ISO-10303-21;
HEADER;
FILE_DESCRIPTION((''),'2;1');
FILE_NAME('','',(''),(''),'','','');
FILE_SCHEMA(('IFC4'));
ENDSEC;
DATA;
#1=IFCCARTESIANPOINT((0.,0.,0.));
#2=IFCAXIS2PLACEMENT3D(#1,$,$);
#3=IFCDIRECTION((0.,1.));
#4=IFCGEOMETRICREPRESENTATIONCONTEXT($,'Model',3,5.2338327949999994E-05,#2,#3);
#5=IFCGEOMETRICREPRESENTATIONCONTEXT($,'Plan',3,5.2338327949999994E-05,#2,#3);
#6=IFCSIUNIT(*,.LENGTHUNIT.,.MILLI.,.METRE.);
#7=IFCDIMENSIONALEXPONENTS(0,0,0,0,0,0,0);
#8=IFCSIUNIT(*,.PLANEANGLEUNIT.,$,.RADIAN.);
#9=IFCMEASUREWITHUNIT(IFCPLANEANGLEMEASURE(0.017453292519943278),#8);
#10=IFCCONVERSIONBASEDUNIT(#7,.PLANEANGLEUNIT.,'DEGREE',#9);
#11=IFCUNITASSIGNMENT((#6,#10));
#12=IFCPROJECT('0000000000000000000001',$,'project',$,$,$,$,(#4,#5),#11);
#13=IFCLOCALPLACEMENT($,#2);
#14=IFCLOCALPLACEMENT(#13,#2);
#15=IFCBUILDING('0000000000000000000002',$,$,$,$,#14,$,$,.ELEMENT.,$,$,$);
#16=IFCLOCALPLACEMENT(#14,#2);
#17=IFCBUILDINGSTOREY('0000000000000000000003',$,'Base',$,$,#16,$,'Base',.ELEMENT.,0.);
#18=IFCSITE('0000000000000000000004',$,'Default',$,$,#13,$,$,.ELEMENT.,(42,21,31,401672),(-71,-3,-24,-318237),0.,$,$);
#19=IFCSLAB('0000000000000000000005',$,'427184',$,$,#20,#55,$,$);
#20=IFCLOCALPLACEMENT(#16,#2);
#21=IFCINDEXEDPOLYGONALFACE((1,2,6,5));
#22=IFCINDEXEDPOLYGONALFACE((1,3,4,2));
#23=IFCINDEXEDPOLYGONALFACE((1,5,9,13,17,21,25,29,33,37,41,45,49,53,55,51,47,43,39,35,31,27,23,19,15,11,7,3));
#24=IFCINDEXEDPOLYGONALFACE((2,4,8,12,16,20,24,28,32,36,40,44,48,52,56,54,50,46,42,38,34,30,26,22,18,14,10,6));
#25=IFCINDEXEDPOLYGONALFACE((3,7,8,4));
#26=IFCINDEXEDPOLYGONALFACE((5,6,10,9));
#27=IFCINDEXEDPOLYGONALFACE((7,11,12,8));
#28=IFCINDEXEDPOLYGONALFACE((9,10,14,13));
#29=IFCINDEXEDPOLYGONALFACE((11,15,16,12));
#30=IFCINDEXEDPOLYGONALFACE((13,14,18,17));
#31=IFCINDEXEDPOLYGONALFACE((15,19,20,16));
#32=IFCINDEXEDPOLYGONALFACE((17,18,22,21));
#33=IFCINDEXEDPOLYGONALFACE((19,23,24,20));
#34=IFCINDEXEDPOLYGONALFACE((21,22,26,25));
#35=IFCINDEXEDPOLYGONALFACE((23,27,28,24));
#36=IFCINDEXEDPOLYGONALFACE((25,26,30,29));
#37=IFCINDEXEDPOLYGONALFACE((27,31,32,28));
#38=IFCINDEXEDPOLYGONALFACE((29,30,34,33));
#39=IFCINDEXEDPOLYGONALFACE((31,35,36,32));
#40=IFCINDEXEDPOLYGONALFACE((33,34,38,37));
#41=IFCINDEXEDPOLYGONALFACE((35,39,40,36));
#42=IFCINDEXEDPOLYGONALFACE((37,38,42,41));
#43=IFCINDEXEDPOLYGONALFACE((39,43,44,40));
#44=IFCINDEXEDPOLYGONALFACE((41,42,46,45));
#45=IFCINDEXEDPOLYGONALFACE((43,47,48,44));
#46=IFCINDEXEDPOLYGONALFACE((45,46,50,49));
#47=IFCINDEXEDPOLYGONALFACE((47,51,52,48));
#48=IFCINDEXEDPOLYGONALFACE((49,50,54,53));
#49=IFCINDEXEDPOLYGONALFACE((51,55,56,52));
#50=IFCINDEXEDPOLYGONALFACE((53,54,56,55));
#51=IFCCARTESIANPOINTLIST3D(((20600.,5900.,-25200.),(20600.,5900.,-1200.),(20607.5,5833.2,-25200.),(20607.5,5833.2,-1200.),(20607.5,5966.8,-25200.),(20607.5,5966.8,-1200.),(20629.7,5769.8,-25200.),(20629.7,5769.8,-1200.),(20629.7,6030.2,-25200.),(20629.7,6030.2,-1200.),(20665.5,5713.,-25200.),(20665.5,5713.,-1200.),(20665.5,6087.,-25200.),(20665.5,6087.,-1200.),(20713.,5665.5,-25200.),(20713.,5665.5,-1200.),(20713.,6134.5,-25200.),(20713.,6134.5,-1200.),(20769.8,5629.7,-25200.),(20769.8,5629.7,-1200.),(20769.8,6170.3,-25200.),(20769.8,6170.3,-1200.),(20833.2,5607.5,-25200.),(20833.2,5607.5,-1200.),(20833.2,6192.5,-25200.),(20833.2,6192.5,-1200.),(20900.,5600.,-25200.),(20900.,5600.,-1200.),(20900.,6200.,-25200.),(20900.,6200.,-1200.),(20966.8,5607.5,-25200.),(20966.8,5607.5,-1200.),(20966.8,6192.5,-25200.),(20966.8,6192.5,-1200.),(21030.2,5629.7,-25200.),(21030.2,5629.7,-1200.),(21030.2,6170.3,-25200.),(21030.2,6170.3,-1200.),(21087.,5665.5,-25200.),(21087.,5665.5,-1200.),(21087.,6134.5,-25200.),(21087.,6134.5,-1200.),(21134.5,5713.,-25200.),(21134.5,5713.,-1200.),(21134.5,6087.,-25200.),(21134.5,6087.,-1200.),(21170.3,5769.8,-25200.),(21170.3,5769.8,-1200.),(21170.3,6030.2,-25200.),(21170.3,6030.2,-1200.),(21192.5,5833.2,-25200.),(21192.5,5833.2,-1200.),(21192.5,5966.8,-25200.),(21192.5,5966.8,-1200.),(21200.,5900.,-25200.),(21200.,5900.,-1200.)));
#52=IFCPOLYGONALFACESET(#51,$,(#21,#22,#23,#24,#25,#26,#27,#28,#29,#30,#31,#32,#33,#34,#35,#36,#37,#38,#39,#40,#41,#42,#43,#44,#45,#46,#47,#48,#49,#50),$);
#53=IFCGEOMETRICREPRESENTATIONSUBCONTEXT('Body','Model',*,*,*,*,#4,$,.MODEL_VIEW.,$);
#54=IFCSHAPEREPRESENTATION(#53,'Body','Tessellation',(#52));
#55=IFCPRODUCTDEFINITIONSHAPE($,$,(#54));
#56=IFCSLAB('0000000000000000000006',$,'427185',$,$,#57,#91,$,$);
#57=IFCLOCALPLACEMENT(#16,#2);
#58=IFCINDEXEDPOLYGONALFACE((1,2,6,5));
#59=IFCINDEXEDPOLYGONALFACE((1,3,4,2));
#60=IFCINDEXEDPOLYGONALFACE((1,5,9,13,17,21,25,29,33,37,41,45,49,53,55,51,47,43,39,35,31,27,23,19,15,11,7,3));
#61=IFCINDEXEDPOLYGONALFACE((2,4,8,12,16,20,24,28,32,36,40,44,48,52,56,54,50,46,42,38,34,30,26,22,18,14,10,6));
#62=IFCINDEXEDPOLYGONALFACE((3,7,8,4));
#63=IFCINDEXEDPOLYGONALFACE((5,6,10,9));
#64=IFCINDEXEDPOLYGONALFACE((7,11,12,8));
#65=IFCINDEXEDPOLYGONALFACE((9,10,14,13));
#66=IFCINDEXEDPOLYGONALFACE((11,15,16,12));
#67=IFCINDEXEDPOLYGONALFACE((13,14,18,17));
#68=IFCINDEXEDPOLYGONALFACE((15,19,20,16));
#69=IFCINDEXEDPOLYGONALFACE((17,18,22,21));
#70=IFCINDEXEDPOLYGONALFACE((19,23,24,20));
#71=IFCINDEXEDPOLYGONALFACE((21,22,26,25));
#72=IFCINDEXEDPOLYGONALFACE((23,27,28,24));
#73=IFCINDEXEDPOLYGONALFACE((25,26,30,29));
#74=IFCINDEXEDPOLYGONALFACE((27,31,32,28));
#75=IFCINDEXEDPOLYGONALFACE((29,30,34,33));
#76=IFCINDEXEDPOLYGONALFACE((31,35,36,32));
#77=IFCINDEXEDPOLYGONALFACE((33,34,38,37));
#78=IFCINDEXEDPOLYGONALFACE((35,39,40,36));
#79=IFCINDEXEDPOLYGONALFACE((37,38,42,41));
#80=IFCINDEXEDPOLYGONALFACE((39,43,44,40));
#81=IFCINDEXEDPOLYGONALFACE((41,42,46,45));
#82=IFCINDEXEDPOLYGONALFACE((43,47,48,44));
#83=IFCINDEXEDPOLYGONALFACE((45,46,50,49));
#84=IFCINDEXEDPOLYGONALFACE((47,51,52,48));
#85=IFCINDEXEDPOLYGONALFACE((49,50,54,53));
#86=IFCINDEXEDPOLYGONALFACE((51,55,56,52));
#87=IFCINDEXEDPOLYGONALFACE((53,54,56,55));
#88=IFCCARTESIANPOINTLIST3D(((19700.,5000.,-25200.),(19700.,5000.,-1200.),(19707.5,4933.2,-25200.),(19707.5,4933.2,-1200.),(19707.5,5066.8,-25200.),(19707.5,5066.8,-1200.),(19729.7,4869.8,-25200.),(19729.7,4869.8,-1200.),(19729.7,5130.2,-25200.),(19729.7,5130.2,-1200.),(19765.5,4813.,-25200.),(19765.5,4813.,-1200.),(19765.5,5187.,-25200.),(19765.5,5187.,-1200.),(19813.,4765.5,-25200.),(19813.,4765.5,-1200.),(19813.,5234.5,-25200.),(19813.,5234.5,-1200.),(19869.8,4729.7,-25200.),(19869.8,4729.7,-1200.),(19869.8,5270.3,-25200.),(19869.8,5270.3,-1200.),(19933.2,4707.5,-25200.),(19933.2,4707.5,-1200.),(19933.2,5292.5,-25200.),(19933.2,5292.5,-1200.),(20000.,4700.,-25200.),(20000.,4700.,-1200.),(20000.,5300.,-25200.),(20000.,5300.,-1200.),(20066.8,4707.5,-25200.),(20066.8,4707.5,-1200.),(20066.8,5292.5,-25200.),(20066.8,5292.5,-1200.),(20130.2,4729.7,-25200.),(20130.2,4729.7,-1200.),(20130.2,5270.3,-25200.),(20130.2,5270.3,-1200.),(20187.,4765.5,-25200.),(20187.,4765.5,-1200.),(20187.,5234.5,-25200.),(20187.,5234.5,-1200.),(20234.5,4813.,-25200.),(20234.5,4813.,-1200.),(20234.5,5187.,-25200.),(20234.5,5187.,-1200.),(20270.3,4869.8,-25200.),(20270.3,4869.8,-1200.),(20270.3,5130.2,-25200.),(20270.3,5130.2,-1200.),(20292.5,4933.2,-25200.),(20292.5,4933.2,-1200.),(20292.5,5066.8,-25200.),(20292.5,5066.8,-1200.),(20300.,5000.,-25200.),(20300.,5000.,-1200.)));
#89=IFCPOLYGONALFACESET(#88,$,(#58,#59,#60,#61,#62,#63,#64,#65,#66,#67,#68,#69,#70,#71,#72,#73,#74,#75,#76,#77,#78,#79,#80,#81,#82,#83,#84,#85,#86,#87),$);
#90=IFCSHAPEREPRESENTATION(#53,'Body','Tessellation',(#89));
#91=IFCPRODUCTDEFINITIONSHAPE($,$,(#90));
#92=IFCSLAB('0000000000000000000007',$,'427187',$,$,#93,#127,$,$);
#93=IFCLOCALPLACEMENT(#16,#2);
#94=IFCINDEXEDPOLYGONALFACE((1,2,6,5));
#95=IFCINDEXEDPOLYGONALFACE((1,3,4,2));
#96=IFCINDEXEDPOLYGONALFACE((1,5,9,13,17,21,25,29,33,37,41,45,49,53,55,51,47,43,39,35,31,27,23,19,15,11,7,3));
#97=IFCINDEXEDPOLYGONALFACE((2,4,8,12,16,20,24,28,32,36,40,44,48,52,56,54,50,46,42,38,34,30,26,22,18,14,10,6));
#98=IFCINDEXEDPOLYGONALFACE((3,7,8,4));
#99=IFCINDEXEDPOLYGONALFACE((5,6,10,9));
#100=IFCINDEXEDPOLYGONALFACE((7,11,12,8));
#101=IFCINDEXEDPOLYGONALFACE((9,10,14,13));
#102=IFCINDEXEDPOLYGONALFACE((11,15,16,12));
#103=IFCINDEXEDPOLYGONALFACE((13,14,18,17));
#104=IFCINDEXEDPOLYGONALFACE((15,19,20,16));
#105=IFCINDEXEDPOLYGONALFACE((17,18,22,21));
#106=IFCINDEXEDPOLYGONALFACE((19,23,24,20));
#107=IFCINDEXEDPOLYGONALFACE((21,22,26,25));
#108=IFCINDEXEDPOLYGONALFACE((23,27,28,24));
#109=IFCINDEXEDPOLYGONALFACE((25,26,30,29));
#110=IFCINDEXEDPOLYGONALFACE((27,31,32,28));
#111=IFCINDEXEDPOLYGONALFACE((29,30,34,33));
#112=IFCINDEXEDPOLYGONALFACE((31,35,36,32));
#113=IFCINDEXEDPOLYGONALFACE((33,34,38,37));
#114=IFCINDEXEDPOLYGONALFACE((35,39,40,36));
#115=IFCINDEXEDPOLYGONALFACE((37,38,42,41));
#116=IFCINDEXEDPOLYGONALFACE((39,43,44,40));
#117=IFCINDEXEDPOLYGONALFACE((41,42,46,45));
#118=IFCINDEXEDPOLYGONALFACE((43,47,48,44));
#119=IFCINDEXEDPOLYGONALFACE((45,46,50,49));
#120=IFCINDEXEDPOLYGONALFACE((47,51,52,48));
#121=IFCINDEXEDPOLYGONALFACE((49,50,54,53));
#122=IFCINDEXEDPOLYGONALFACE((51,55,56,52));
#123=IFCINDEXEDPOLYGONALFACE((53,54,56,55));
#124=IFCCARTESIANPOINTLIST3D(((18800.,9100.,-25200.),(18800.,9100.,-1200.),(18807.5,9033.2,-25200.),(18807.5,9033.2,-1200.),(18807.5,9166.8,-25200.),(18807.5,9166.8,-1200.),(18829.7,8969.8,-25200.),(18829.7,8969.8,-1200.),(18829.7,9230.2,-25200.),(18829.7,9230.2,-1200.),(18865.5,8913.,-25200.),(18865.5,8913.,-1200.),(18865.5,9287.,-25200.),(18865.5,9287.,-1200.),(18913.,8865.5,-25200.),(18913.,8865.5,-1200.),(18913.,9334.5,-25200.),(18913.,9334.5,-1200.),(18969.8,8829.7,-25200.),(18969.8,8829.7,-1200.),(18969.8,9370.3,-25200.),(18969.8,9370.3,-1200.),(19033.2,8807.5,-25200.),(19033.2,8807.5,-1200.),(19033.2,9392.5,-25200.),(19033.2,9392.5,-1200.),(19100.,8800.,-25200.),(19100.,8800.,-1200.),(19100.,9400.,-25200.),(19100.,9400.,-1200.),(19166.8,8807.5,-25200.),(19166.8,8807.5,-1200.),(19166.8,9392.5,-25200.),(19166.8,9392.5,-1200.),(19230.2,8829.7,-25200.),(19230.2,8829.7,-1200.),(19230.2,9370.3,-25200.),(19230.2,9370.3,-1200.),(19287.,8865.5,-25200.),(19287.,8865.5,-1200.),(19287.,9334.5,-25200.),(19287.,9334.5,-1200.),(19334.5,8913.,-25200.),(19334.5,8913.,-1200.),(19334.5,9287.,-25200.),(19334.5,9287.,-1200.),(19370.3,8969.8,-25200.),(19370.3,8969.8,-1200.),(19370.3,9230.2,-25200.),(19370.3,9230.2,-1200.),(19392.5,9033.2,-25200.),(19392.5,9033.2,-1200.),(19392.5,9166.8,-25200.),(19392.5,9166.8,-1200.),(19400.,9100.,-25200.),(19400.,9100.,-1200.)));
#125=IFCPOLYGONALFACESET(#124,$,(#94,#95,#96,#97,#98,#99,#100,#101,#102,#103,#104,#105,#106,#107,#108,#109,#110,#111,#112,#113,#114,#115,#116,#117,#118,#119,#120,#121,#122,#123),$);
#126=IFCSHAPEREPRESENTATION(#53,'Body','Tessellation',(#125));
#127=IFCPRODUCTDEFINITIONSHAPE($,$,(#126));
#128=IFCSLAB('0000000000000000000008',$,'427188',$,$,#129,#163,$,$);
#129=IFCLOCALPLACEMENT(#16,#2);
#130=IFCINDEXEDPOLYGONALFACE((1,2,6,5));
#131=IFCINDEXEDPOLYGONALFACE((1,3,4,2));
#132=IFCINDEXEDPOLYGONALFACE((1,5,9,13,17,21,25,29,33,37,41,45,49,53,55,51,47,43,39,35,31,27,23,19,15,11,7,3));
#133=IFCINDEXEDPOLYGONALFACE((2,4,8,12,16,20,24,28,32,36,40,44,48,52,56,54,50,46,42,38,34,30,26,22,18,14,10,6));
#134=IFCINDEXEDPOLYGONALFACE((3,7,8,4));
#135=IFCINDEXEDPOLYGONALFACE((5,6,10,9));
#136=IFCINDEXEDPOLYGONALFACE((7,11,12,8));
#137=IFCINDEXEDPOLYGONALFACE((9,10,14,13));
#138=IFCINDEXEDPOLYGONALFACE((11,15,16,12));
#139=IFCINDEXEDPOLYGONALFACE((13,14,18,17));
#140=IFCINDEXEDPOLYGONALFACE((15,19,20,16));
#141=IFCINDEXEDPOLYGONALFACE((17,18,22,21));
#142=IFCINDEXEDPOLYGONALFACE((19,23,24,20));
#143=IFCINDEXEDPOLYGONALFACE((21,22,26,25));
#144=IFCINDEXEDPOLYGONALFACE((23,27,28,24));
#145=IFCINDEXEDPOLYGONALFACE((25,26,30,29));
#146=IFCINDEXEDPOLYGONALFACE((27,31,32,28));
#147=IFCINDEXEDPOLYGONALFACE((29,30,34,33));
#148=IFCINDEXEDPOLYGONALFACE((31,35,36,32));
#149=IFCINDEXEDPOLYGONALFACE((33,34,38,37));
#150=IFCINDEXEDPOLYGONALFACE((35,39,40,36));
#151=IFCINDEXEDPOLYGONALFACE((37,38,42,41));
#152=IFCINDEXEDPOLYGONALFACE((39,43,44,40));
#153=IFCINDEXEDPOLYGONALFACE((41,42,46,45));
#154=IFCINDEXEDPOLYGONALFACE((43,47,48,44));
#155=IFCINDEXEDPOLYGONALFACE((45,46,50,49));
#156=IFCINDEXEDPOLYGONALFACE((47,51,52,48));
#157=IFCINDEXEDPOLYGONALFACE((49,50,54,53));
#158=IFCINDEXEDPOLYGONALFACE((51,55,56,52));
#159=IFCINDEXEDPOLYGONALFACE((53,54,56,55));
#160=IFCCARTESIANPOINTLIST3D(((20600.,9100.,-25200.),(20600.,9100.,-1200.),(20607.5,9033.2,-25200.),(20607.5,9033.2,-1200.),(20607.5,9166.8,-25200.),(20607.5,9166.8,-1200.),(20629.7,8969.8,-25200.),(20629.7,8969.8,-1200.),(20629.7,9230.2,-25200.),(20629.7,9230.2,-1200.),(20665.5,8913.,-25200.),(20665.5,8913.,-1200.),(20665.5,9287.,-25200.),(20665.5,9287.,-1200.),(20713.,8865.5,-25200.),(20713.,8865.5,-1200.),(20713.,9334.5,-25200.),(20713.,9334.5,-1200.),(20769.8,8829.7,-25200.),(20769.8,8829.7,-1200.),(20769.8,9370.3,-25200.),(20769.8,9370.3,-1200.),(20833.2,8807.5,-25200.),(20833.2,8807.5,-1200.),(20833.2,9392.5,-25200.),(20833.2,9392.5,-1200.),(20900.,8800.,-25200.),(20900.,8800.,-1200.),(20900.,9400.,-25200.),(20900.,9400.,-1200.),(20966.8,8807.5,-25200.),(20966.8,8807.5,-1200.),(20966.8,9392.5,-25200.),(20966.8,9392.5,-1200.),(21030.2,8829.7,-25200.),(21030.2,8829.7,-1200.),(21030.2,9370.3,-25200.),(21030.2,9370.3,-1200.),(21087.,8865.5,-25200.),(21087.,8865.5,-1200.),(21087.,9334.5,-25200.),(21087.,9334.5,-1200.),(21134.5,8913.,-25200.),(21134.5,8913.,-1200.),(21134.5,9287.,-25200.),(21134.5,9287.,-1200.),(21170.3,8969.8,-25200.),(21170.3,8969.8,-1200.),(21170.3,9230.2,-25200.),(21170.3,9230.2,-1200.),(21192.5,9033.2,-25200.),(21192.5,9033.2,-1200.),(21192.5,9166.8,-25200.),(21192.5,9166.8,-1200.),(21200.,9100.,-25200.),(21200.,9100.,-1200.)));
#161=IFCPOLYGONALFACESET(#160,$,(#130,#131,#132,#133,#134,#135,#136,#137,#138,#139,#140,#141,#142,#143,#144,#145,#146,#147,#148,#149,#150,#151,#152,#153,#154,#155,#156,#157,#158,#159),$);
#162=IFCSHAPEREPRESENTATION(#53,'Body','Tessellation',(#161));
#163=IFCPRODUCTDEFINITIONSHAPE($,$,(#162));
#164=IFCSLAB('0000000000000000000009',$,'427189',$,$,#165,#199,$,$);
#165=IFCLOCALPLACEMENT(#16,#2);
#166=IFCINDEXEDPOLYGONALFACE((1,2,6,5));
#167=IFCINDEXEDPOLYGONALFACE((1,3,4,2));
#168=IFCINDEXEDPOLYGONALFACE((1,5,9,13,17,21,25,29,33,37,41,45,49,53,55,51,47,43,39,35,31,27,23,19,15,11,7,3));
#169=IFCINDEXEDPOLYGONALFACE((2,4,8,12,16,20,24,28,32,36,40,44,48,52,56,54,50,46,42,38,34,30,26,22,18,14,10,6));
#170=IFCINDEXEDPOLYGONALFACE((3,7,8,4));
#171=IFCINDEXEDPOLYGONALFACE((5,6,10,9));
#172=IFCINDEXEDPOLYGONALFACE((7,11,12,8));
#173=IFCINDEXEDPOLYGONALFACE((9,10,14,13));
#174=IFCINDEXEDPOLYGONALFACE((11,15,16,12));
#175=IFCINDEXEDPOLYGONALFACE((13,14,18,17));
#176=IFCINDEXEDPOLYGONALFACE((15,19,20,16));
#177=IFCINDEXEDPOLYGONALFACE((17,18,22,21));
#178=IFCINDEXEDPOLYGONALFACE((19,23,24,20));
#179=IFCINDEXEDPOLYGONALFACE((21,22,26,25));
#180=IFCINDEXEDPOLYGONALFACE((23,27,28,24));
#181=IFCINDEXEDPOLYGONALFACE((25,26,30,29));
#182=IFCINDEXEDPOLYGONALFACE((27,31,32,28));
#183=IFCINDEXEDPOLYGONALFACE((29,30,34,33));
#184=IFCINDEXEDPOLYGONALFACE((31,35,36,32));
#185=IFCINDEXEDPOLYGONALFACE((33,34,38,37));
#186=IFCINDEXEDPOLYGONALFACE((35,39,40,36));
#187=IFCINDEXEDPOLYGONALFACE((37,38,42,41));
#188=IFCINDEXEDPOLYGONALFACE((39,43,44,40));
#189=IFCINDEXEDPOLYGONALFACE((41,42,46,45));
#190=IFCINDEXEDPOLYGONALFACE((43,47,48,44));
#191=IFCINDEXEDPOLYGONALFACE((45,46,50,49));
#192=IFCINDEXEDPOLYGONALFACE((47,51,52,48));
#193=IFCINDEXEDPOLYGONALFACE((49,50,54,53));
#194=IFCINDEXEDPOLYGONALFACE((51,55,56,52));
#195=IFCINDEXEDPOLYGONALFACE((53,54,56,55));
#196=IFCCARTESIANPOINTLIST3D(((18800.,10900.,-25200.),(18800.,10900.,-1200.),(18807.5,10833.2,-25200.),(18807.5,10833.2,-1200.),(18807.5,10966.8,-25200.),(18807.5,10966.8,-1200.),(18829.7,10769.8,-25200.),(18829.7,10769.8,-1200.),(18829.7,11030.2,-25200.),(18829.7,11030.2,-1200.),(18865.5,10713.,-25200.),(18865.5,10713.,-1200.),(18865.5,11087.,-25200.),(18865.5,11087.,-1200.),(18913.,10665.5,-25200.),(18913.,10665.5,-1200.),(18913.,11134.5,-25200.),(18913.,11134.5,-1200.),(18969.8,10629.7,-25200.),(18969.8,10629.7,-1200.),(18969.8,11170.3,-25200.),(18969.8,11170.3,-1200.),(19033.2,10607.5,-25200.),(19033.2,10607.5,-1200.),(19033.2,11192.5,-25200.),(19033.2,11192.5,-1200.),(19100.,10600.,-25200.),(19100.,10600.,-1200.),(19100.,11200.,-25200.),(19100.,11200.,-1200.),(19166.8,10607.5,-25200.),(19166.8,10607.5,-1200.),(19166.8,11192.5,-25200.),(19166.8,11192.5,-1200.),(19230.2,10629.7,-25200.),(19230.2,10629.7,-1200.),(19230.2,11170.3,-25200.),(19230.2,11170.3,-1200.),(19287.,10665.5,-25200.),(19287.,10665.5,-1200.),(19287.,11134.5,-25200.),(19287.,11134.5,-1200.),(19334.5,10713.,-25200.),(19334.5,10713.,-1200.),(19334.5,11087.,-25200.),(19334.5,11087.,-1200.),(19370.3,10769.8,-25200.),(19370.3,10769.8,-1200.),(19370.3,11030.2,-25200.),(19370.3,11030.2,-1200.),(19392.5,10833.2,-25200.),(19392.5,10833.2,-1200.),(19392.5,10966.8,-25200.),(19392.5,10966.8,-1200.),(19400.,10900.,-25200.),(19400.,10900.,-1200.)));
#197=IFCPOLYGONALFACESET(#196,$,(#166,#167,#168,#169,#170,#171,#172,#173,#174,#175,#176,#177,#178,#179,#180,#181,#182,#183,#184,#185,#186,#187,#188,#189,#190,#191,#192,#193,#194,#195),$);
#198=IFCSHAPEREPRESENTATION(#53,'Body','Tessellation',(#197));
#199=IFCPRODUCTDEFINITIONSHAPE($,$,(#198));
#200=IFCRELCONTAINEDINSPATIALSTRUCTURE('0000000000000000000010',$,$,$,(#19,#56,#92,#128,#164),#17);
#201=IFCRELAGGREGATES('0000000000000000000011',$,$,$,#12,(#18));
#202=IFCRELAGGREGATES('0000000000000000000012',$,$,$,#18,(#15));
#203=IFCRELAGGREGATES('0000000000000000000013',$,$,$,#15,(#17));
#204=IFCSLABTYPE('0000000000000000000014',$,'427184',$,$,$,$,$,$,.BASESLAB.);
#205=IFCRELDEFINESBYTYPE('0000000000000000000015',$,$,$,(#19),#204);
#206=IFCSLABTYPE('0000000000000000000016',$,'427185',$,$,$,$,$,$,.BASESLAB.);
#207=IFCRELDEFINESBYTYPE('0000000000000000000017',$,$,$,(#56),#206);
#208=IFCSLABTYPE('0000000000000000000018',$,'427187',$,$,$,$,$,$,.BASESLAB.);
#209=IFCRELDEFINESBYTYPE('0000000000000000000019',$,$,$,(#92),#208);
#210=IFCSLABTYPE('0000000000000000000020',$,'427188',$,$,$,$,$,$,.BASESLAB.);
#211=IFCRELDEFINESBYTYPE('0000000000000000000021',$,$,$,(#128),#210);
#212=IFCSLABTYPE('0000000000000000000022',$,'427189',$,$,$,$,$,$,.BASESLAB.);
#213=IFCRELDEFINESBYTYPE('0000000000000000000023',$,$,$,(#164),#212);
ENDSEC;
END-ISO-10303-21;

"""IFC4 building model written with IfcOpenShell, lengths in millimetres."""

from ifc_helpers import new_model, entity, si_unit, converted_unit, direction, frame, origin, place, context, subcontext, project, spatial, arc, indexed_curve, outline, extrude, type_object, element, save


model = new_model("IFC4")

# Units and contexts
model_context = context("Model", 3, precision=5.2338327949999994e-05, world=origin(), true_north=direction((0.0, 1.0)))
plan_context = context("Plan", 3, precision=5.2338327949999994e-05, world=origin(), true_north=direction((0.0, 1.0)))
body_context = subcontext(model_context, "Body", "Model", "MODEL_VIEW")
ifc_project = project(units=[si_unit("LENGTHUNIT", "METRE", prefix="MILLI"), converted_unit("PLANEANGLEUNIT", "DEGREE", entity("IfcPlaneAngleMeasure", 0.017453292519943278), si_unit("PLANEANGLEUNIT", "RADIAN"), dimensions=[0, 0, 0, 0, 0, 0, 0])], contexts=[model_context, plan_context])

# Site, building, storey
site_placement = place(None, origin())
site = spatial("IfcSite", under=ifc_project, at=site_placement, Name="Default", CompositionType="ELEMENT", RefLatitude=(42, 21, 31, 401672), RefLongitude=(-71, -3, -24, -318237), RefElevation=0.0)
building_placement = place(site_placement, origin())
building = spatial("IfcBuilding", under=site, at=building_placement, CompositionType="ELEMENT")
storey_placement = place(building_placement, origin())
storey = spatial("IfcBuildingStorey", under=building, at=storey_placement, Name="Base", LongName="Base", CompositionType="ELEMENT", Elevation=0.0)

# Slabs
slab_type_1 = type_object("IfcSlabType", Name="427184", PredefinedType="BASESLAB")
slab_1_placement = place(storey_placement, origin())
element("IfcSlab", 1, at=slab_1_placement, inside=storey, type_object=slab_type_1, Name="427184", context=body_context, shape_type="SweptSolid", body=[
    extrude(outline(indexed_curve([(300.0, 0.0), (0.0, 300.0), (-300.0, 0.0), (0.0, -300.0)], segments=[arc(1, 2, 3), arc(3, 4, 1)], self_intersect=False)), frame((20900.0, 5900.0, -25200.0)), (0.0, 0.0, 1.0), 24000.0),
])
slab_type_2 = type_object("IfcSlabType", Name="427185", PredefinedType="BASESLAB")
slab_2_placement = place(storey_placement, origin())
element("IfcSlab", 2, at=slab_2_placement, inside=storey, type_object=slab_type_2, Name="427185", context=body_context, shape_type="SweptSolid", body=[
    extrude(outline(indexed_curve([(300.0, 0.0), (0.0, 300.0), (-300.0, 0.0), (0.0, -300.0)], segments=[arc(1, 2, 3), arc(3, 4, 1)], self_intersect=False)), frame((20000.0, 5000.0, -25200.0)), (0.0, 0.0, 1.0), 24000.0),
])
slab_type_3 = type_object("IfcSlabType", Name="427187", PredefinedType="BASESLAB")
slab_3_placement = place(storey_placement, origin())
element("IfcSlab", 3, at=slab_3_placement, inside=storey, type_object=slab_type_3, Name="427187", context=body_context, shape_type="SweptSolid", body=[
    extrude(outline(indexed_curve([(300.0, 0.0), (0.0, 300.0), (-300.0, 0.0), (0.0, -300.0)], segments=[arc(1, 2, 3), arc(3, 4, 1)], self_intersect=False)), frame((19100.0, 9100.0, -25200.0)), (0.0, 0.0, 1.0), 24000.0),
])
slab_type_4 = type_object("IfcSlabType", Name="427188", PredefinedType="BASESLAB")
slab_4_placement = place(storey_placement, origin())
element("IfcSlab", 4, at=slab_4_placement, inside=storey, type_object=slab_type_4, Name="427188", context=body_context, shape_type="SweptSolid", body=[
    extrude(outline(indexed_curve([(300.0, 0.0), (0.0, 300.0), (-300.0, 0.0), (0.0, -300.0)], segments=[arc(1, 2, 3), arc(3, 4, 1)], self_intersect=False)), frame((20900.0, 9100.0, -25200.0)), (0.0, 0.0, 1.0), 24000.0),
])
slab_type_5 = type_object("IfcSlabType", Name="427189", PredefinedType="BASESLAB")
slab_5_placement = place(storey_placement, origin())
element("IfcSlab", 5, at=slab_5_placement, inside=storey, type_object=slab_type_5, Name="427189", context=body_context, shape_type="SweptSolid", body=[
    extrude(outline(indexed_curve([(300.0, 0.0), (0.0, 300.0), (-300.0, 0.0), (0.0, -300.0)], segments=[arc(1, 2, 3), arc(3, 4, 1)], self_intersect=False)), frame((19100.0, 10900.0, -25200.0)), (0.0, 0.0, 1.0), 24000.0),
])

save(model, "model.ifc")
